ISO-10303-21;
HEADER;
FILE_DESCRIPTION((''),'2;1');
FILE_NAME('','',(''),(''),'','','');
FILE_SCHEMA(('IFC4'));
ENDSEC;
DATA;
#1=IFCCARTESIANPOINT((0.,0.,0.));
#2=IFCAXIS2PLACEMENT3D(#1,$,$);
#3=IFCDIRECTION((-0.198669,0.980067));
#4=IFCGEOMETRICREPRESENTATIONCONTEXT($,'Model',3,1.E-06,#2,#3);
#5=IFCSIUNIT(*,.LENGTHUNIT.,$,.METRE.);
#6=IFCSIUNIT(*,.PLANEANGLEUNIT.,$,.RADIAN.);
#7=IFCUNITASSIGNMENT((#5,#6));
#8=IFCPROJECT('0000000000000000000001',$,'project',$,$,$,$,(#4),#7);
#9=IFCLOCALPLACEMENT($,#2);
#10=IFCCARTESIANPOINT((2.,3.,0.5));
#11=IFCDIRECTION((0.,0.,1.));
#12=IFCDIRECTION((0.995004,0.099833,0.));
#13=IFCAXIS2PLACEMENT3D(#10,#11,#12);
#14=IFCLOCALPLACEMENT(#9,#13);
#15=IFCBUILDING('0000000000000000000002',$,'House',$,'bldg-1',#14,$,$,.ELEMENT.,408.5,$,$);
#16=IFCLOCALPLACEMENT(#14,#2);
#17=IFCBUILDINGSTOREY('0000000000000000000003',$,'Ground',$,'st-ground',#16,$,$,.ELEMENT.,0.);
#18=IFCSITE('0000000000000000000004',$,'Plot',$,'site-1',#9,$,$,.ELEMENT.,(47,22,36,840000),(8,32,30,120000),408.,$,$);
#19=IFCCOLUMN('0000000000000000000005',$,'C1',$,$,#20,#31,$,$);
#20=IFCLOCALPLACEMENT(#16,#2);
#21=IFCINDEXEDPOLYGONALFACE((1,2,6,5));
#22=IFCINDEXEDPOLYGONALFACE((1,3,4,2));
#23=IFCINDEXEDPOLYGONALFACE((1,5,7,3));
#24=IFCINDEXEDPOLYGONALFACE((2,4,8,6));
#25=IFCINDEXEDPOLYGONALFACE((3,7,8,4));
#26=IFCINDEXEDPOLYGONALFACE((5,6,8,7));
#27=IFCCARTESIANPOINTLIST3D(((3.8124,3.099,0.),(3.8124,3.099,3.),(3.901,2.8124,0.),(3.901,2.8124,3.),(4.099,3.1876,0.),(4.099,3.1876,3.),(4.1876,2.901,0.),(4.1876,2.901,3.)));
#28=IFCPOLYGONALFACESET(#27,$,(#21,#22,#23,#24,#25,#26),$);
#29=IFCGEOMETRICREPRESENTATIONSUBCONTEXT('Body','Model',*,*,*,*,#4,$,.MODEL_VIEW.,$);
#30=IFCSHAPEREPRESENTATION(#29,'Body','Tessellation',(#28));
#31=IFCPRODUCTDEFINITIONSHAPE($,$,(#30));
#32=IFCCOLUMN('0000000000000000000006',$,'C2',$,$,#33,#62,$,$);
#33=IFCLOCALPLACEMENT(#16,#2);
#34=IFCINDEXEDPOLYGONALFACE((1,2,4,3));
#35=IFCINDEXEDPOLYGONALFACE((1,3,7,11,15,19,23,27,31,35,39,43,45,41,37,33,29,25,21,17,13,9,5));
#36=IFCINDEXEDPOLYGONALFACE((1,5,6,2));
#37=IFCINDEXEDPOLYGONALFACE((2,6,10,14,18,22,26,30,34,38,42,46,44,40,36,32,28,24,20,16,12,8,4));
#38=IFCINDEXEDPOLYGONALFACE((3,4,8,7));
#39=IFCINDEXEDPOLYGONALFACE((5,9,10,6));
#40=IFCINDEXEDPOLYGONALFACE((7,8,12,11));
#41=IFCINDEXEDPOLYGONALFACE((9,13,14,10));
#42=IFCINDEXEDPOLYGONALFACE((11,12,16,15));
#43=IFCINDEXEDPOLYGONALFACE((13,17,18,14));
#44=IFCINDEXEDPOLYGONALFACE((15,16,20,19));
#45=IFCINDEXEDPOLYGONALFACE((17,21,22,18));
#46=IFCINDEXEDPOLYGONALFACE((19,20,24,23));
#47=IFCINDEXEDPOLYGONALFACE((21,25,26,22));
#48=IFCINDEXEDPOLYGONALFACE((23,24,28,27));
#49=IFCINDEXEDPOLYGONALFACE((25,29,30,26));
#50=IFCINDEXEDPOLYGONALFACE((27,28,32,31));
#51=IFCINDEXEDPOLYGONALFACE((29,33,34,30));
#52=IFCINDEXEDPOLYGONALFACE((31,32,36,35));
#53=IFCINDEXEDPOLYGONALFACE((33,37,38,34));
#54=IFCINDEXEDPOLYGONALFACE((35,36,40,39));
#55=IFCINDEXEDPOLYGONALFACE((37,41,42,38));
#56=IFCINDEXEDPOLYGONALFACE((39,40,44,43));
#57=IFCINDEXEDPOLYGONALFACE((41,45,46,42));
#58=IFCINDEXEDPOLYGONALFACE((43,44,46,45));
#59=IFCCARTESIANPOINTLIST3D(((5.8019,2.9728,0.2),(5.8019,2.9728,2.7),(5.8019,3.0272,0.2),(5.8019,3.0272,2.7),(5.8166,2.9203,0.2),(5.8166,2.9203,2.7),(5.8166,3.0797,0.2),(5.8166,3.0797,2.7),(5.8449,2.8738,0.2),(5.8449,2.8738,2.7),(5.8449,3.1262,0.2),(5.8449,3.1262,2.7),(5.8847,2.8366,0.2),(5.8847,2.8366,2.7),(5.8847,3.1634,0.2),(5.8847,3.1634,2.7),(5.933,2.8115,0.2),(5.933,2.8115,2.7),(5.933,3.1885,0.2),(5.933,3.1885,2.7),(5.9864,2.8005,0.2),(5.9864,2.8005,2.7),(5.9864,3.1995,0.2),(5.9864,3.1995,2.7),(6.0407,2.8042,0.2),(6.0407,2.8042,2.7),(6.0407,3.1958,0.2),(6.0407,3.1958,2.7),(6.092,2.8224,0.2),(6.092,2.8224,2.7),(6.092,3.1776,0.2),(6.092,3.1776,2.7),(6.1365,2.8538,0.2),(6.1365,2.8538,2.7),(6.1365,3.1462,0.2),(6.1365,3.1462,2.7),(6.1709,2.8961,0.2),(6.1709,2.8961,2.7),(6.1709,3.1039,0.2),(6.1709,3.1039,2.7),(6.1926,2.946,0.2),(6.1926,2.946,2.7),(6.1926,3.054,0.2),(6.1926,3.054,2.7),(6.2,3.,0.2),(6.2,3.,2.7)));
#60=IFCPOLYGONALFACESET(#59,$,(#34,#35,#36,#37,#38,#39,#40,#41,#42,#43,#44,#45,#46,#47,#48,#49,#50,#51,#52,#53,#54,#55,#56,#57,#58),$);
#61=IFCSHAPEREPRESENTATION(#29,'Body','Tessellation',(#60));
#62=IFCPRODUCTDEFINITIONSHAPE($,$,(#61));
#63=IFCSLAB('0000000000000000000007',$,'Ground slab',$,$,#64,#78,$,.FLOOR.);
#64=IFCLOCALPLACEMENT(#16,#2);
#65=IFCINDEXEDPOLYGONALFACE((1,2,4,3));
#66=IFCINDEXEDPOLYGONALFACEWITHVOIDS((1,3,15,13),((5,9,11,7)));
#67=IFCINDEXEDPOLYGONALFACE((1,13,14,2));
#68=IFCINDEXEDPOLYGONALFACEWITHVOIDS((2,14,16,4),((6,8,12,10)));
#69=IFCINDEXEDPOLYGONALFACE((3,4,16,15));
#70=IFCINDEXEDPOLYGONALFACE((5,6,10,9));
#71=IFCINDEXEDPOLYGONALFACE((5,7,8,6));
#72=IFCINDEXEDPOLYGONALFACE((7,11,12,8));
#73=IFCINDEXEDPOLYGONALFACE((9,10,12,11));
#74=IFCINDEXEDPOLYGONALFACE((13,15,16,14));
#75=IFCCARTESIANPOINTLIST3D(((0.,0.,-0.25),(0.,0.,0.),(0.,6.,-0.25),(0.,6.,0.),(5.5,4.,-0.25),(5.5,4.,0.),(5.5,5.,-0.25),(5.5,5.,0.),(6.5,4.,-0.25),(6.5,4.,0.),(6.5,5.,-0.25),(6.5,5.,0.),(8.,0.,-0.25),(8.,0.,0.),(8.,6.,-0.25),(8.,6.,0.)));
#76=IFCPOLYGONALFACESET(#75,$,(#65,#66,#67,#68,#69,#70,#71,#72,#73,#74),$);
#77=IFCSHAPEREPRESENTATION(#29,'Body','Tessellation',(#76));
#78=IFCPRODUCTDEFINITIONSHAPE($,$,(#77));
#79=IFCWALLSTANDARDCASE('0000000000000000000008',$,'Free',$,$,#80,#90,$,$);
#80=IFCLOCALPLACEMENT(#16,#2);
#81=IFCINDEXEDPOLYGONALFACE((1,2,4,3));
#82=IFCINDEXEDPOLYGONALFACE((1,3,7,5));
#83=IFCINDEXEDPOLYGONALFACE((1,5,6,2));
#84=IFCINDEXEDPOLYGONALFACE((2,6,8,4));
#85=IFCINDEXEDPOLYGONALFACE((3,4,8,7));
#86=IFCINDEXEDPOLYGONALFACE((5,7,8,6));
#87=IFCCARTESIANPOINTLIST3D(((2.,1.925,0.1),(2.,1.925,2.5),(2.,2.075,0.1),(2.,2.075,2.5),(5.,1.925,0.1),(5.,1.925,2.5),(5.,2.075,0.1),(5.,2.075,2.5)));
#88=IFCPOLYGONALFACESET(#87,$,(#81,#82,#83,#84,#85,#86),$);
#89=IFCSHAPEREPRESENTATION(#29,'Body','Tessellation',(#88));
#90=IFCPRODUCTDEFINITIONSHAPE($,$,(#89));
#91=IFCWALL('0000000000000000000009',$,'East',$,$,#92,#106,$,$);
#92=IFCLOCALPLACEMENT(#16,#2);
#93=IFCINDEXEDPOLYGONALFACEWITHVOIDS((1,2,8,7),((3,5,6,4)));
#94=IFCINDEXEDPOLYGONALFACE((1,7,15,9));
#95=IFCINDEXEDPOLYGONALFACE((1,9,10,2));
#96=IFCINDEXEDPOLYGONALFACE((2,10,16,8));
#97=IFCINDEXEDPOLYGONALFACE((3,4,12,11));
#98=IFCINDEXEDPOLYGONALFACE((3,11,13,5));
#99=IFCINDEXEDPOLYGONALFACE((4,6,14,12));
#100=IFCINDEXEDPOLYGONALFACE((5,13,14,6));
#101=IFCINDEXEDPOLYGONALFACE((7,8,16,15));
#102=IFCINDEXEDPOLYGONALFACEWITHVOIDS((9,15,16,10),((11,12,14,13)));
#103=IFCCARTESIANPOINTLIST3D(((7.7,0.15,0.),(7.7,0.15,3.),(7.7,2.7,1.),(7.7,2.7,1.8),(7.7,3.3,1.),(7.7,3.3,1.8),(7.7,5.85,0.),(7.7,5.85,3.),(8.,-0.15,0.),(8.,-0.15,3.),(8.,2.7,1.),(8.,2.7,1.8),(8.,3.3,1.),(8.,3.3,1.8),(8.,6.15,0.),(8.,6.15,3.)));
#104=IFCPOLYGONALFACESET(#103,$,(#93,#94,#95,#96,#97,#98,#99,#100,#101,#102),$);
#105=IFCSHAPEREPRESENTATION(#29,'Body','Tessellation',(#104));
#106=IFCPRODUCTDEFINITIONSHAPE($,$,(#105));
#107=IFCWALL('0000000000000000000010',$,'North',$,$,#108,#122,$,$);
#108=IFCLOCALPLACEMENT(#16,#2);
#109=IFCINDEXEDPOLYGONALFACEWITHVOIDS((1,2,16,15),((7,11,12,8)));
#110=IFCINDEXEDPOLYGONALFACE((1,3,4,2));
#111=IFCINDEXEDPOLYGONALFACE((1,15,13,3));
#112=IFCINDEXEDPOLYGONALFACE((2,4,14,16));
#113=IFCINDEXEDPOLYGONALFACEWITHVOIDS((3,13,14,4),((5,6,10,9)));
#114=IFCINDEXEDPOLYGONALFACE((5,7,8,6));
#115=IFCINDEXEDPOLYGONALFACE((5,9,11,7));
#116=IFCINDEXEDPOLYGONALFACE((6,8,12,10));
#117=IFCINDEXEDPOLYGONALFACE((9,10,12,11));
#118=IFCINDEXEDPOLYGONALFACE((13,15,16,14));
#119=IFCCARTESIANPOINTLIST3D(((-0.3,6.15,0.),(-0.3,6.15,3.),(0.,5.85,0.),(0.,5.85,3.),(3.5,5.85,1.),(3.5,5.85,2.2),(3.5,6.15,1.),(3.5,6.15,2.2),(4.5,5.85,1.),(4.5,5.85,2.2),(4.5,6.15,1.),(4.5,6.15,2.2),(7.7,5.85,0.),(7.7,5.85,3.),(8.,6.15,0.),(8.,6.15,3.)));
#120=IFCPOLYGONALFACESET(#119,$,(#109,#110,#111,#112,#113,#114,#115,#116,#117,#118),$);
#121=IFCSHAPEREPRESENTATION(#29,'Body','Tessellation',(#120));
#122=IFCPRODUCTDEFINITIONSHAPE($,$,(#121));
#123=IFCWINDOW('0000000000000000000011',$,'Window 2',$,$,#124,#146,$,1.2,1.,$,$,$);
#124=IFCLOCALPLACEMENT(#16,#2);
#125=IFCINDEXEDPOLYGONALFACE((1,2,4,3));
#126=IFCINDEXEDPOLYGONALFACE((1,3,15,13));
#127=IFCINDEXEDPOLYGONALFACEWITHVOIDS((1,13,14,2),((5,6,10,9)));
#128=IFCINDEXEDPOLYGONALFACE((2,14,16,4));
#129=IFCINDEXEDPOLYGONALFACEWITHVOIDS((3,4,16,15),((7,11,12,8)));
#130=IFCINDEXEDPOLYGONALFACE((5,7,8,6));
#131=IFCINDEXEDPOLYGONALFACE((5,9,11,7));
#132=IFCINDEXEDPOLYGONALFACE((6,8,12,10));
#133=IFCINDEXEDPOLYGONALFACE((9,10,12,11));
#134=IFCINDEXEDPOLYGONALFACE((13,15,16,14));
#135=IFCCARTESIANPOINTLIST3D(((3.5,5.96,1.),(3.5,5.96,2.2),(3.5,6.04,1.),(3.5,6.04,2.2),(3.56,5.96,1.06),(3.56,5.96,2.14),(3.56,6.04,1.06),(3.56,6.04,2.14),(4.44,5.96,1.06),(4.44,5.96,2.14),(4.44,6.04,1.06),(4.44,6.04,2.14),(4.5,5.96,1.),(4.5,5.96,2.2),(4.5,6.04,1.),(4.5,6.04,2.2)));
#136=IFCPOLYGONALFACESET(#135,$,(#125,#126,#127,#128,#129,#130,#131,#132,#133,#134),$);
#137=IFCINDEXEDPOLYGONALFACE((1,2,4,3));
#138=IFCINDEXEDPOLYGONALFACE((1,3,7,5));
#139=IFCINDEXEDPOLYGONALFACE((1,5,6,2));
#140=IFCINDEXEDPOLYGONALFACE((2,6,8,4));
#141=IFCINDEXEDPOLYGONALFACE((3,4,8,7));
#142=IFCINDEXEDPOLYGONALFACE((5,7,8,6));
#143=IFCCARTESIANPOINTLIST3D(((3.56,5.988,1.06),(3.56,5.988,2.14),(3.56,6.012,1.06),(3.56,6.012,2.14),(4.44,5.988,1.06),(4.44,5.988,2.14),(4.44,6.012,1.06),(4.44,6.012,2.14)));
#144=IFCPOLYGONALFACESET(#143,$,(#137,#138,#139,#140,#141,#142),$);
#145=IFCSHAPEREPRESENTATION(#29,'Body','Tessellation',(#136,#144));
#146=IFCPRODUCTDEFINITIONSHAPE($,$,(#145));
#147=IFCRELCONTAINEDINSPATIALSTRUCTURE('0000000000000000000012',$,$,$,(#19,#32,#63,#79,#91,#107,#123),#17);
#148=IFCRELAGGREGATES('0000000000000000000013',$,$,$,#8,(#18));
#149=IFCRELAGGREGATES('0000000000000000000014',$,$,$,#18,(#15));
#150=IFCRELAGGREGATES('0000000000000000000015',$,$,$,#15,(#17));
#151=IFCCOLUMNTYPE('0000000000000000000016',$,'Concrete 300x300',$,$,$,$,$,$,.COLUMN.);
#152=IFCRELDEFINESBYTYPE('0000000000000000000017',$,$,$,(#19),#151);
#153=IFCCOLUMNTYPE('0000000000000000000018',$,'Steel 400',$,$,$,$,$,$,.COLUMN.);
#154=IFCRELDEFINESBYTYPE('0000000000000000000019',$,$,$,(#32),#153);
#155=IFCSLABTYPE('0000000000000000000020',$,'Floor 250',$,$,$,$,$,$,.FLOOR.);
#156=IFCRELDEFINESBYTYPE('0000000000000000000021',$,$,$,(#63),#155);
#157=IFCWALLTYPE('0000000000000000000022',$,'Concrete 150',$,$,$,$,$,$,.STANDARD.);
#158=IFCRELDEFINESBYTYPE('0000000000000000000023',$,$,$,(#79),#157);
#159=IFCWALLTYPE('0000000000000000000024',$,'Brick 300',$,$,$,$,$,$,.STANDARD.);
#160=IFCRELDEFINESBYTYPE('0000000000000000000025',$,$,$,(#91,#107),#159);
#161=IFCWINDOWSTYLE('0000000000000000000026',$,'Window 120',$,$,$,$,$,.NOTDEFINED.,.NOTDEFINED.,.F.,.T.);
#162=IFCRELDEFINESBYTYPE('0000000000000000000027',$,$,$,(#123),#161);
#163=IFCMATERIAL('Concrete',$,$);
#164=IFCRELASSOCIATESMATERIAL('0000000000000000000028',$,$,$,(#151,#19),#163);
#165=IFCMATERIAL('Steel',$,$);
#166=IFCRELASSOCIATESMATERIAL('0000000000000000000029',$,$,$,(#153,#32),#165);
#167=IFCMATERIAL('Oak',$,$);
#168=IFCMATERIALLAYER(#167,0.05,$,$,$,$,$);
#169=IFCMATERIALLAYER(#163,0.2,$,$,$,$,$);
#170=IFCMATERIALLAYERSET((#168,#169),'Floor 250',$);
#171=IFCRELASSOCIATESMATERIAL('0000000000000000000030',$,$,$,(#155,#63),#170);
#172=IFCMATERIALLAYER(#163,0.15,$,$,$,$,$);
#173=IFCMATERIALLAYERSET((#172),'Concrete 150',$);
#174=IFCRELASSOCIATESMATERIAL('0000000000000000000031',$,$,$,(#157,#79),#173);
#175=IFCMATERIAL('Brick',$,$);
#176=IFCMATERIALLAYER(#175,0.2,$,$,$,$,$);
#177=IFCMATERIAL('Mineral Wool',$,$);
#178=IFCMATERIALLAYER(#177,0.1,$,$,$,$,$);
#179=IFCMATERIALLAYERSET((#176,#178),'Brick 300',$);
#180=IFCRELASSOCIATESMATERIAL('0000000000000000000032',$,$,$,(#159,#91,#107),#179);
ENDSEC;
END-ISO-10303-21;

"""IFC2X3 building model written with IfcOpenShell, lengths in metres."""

from ifc_helpers import new_model, si_unit, direction, frame, frame_2d, origin, origin_2d, place, context, subcontext, project, spatial, polyline, rectangle, circle, outline, extrude, material, layer, layer_set, layer_usage, type_object, element, fill, save


model = new_model("IFC2X3")

# Units and contexts
model_context = context("Model", 3, precision=1e-06, world=origin(), true_north=direction((-0.198669, 0.980067)))
body_context = subcontext(model_context, "Body", "Model", "MODEL_VIEW")
ifc_project = project(units=[si_unit("LENGTHUNIT", "METRE"), si_unit("PLANEANGLEUNIT", "RADIAN")], contexts=[model_context])

# Site, building, storey
site_placement = place(None, origin())
site = spatial("IfcSite", under=ifc_project, at=site_placement, Name="Plot", ObjectType="site-1", CompositionType="ELEMENT", RefLatitude=(47, 22, 36, 840000), RefLongitude=(8, 32, 30, 120000), RefElevation=408.0)
building_placement = place(site_placement, frame((2.0, 3.0, 0.5), z_axis=(0.0, 0.0, 1.0), x_axis=(0.995004, 0.099833, 0.0)))
building = spatial("IfcBuilding", under=site, at=building_placement, Name="House", ObjectType="bldg-1", CompositionType="ELEMENT", ElevationOfRefHeight=408.5)
storey_placement = place(building_placement, origin())
storey = spatial("IfcBuildingStorey", under=building, at=storey_placement, Name="Ground", ObjectType="st-ground", CompositionType="ELEMENT", Elevation=0.0)

# Columns
ifc_material_1 = material(Name="Concrete")
column_type_1 = type_object("IfcColumnType", Name="Concrete 300x300", PredefinedType="COLUMN", material=ifc_material_1)
column_1_placement = place(storey_placement, frame((4.0, 3.0, 0.0), z_axis=(0.0, 0.0, 1.0), x_axis=(0.955336, 0.29552, 0.0)))
element("IfcColumn", 1, at=column_1_placement, inside=storey, type_object=column_type_1, material=ifc_material_1, Name="C1", context=body_context, shape_type="SweptSolid", body=[
    extrude(rectangle(XDim=0.3, YDim=0.3, at=origin_2d()), origin(), (0.0, 0.0, 1.0), 3.0),
])
ifc_material_2 = material(Name="Steel")
column_type_2 = type_object("IfcColumnType", Name="Steel 400", PredefinedType="COLUMN", material=ifc_material_2)
column_2_placement = place(storey_placement, frame((6.0, 3.0, 0.2)))
element("IfcColumn", 2, at=column_2_placement, inside=storey, type_object=column_type_2, material=ifc_material_2, Name="C2", context=body_context, shape_type="SweptSolid", body=[
    extrude(circle(Radius=0.2, at=origin_2d()), origin(), (0.0, 0.0, 1.0), 2.5),
])

# Slab
ifc_material_3 = material(Name="Oak")
ifc_layer_1 = layer(ifc_material_3, 0.05)
ifc_layer_2 = layer(ifc_material_1, 0.2)
ifc_layer_set_1 = layer_set([ifc_layer_1, ifc_layer_2], Name="Floor 250")
ifc_layer_usage_1 = layer_usage(ifc_layer_set_1, "AXIS3", "NEGATIVE", 0.25)
slab_type = type_object("IfcSlabType", Name="Floor 250", PredefinedType="FLOOR", material=ifc_layer_set_1)
slab_placement = place(storey_placement, frame((0.0, 0.0, -0.25)))
element("IfcSlab", 3, at=slab_placement, inside=storey, type_object=slab_type, material=ifc_layer_usage_1, Name="Ground slab", PredefinedType="FLOOR", context=body_context, shape_type="SweptSolid", body=[
    extrude(outline(polyline([(0.0, 0.0), (8.0, 0.0), (8.0, 6.0), (0.0, 6.0), (0.0, 0.0)]), holes=[polyline([(5.5, 4.0), (5.5, 5.0), (6.5, 5.0), (6.5, 4.0), (5.5, 4.0)])]), origin(), (0.0, 0.0, 1.0), 0.25),
])

# Shared definitions
ifc_layer_3 = layer(ifc_material_1, 0.15)
ifc_layer_set_2 = layer_set([ifc_layer_3], Name="Concrete 150")
wall_type_1 = type_object("IfcWallType", Name="Concrete 150", PredefinedType="STANDARD", material=ifc_layer_set_2)
window_style = type_object("IfcWindowStyle", Name="Window 120", ConstructionType="NOTDEFINED", OperationType="NOTDEFINED", ParameterTakesPrecedence=False, Sizeable=True)

# Wall
ifc_layer_usage_2 = layer_usage(ifc_layer_set_2, "AXIS2", "NEGATIVE", 0.075)
wall_1_placement = place(storey_placement, frame((2.0, 2.0, 0.1), z_axis=(0.0, 0.0, 1.0), x_axis=(1.0, 0.0, 0.0)))
element("IfcWallStandardCase", 4, at=wall_1_placement, inside=storey, type_object=wall_type_1, material=ifc_layer_usage_2, Name="Free", context=body_context, shape_type="SweptSolid", body=[
    extrude(rectangle(XDim=3.0, YDim=0.15, at=frame_2d((1.5, 0.0))), origin(), (0.0, 0.0, 1.0), 2.4),
])

# Wall, opening
ifc_material_4 = material(Name="Brick")
ifc_layer_4 = layer(ifc_material_4, 0.2)
ifc_material_5 = material(Name="Mineral Wool")
ifc_layer_5 = layer(ifc_material_5, 0.1)
ifc_layer_set_3 = layer_set([ifc_layer_4, ifc_layer_5], Name="Brick 300")
ifc_layer_usage_3 = layer_usage(ifc_layer_set_3, "AXIS2", "NEGATIVE", 0.3)
wall_type_2 = type_object("IfcWallType", Name="Brick 300", PredefinedType="STANDARD", material=ifc_layer_set_3)
wall_2_placement = place(storey_placement, origin())
wall_2 = element("IfcWall", 5, at=wall_2_placement, inside=storey, type_object=wall_type_2, material=ifc_layer_usage_3, Name="East", context=body_context, shape_type="SweptSolid", body=[
    extrude(outline(polyline([(8.0, -0.15), (8.0, 6.15), (7.7, 5.85), (7.7, 0.15), (8.0, -0.15)])), origin(), (0.0, 0.0, 1.0), 3.0),
])
opening_1_placement = place(wall_2_placement, frame((7.85, 3.0, 1.0), z_axis=(0.0, 0.0, 1.0), x_axis=(0.0, 1.0, 0.0)))
element("IfcOpeningElement", 6, at=opening_1_placement, cuts=wall_2, context=body_context, shape_type="SweptSolid", body=[
    extrude(rectangle(XDim=0.6, YDim=0.3, at=origin_2d()), origin(), (0.0, 0.0, 1.0), 0.8),
])

# Wall, opening, window
ifc_layer_usage_4 = layer_usage(ifc_layer_set_3, "AXIS2", "NEGATIVE", 0.15)
wall_3_placement = place(storey_placement, origin())
wall_3 = element("IfcWall", 7, at=wall_3_placement, inside=storey, type_object=wall_type_2, material=ifc_layer_usage_4, Name="North", context=body_context, shape_type="SweptSolid", body=[
    extrude(outline(polyline([(8.0, 6.15), (-0.3, 6.15), (0.0, 5.85), (7.7, 5.85), (8.0, 6.15)])), origin(), (0.0, 0.0, 1.0), 3.0),
])
opening_2_placement = place(wall_3_placement, frame((4.0, 6.0, 1.0), z_axis=(0.0, 0.0, 1.0), x_axis=(-1.0, 0.0, 0.0)))
opening_2 = element("IfcOpeningElement", 8, at=opening_2_placement, cuts=wall_3, context=body_context, shape_type="SweptSolid", body=[
    extrude(rectangle(XDim=1.0, YDim=0.3, at=origin_2d()), origin(), (0.0, 0.0, 1.0), 1.2),
])
window_1_placement = place(opening_2_placement, frame((0.0, 0.0, 0.0), z_axis=(0.0, 1.0, 0.0), x_axis=(-1.0, 0.0, 0.0)))
window_1 = element("IfcWindow", 9, at=window_1_placement, inside=storey, type_object=window_style, Name="Window 2", OverallHeight=1.2, OverallWidth=1.0, context=body_context, shape_type="SweptSolid", body=[
    extrude(outline(polyline([(-0.5, 0.0), (0.5, 0.0), (0.5, 1.2), (-0.5, 1.2), (-0.5, 0.0)]), holes=[polyline([(-0.44, 0.06), (0.44, 0.06), (0.44, 1.14), (-0.44, 1.14), (-0.44, 0.06)])]), frame((0.0, 0.0, -0.04)), (0.0, 0.0, 1.0), 0.08),
    extrude(rectangle(XDim=0.88, YDim=1.08, at=frame_2d((0.0, 0.6))), frame((0.0, 0.0, -0.012)), (0.0, 0.0, 1.0), 0.024),
])
fill(opening_2, window_1)

save(model, "model.ifc")
